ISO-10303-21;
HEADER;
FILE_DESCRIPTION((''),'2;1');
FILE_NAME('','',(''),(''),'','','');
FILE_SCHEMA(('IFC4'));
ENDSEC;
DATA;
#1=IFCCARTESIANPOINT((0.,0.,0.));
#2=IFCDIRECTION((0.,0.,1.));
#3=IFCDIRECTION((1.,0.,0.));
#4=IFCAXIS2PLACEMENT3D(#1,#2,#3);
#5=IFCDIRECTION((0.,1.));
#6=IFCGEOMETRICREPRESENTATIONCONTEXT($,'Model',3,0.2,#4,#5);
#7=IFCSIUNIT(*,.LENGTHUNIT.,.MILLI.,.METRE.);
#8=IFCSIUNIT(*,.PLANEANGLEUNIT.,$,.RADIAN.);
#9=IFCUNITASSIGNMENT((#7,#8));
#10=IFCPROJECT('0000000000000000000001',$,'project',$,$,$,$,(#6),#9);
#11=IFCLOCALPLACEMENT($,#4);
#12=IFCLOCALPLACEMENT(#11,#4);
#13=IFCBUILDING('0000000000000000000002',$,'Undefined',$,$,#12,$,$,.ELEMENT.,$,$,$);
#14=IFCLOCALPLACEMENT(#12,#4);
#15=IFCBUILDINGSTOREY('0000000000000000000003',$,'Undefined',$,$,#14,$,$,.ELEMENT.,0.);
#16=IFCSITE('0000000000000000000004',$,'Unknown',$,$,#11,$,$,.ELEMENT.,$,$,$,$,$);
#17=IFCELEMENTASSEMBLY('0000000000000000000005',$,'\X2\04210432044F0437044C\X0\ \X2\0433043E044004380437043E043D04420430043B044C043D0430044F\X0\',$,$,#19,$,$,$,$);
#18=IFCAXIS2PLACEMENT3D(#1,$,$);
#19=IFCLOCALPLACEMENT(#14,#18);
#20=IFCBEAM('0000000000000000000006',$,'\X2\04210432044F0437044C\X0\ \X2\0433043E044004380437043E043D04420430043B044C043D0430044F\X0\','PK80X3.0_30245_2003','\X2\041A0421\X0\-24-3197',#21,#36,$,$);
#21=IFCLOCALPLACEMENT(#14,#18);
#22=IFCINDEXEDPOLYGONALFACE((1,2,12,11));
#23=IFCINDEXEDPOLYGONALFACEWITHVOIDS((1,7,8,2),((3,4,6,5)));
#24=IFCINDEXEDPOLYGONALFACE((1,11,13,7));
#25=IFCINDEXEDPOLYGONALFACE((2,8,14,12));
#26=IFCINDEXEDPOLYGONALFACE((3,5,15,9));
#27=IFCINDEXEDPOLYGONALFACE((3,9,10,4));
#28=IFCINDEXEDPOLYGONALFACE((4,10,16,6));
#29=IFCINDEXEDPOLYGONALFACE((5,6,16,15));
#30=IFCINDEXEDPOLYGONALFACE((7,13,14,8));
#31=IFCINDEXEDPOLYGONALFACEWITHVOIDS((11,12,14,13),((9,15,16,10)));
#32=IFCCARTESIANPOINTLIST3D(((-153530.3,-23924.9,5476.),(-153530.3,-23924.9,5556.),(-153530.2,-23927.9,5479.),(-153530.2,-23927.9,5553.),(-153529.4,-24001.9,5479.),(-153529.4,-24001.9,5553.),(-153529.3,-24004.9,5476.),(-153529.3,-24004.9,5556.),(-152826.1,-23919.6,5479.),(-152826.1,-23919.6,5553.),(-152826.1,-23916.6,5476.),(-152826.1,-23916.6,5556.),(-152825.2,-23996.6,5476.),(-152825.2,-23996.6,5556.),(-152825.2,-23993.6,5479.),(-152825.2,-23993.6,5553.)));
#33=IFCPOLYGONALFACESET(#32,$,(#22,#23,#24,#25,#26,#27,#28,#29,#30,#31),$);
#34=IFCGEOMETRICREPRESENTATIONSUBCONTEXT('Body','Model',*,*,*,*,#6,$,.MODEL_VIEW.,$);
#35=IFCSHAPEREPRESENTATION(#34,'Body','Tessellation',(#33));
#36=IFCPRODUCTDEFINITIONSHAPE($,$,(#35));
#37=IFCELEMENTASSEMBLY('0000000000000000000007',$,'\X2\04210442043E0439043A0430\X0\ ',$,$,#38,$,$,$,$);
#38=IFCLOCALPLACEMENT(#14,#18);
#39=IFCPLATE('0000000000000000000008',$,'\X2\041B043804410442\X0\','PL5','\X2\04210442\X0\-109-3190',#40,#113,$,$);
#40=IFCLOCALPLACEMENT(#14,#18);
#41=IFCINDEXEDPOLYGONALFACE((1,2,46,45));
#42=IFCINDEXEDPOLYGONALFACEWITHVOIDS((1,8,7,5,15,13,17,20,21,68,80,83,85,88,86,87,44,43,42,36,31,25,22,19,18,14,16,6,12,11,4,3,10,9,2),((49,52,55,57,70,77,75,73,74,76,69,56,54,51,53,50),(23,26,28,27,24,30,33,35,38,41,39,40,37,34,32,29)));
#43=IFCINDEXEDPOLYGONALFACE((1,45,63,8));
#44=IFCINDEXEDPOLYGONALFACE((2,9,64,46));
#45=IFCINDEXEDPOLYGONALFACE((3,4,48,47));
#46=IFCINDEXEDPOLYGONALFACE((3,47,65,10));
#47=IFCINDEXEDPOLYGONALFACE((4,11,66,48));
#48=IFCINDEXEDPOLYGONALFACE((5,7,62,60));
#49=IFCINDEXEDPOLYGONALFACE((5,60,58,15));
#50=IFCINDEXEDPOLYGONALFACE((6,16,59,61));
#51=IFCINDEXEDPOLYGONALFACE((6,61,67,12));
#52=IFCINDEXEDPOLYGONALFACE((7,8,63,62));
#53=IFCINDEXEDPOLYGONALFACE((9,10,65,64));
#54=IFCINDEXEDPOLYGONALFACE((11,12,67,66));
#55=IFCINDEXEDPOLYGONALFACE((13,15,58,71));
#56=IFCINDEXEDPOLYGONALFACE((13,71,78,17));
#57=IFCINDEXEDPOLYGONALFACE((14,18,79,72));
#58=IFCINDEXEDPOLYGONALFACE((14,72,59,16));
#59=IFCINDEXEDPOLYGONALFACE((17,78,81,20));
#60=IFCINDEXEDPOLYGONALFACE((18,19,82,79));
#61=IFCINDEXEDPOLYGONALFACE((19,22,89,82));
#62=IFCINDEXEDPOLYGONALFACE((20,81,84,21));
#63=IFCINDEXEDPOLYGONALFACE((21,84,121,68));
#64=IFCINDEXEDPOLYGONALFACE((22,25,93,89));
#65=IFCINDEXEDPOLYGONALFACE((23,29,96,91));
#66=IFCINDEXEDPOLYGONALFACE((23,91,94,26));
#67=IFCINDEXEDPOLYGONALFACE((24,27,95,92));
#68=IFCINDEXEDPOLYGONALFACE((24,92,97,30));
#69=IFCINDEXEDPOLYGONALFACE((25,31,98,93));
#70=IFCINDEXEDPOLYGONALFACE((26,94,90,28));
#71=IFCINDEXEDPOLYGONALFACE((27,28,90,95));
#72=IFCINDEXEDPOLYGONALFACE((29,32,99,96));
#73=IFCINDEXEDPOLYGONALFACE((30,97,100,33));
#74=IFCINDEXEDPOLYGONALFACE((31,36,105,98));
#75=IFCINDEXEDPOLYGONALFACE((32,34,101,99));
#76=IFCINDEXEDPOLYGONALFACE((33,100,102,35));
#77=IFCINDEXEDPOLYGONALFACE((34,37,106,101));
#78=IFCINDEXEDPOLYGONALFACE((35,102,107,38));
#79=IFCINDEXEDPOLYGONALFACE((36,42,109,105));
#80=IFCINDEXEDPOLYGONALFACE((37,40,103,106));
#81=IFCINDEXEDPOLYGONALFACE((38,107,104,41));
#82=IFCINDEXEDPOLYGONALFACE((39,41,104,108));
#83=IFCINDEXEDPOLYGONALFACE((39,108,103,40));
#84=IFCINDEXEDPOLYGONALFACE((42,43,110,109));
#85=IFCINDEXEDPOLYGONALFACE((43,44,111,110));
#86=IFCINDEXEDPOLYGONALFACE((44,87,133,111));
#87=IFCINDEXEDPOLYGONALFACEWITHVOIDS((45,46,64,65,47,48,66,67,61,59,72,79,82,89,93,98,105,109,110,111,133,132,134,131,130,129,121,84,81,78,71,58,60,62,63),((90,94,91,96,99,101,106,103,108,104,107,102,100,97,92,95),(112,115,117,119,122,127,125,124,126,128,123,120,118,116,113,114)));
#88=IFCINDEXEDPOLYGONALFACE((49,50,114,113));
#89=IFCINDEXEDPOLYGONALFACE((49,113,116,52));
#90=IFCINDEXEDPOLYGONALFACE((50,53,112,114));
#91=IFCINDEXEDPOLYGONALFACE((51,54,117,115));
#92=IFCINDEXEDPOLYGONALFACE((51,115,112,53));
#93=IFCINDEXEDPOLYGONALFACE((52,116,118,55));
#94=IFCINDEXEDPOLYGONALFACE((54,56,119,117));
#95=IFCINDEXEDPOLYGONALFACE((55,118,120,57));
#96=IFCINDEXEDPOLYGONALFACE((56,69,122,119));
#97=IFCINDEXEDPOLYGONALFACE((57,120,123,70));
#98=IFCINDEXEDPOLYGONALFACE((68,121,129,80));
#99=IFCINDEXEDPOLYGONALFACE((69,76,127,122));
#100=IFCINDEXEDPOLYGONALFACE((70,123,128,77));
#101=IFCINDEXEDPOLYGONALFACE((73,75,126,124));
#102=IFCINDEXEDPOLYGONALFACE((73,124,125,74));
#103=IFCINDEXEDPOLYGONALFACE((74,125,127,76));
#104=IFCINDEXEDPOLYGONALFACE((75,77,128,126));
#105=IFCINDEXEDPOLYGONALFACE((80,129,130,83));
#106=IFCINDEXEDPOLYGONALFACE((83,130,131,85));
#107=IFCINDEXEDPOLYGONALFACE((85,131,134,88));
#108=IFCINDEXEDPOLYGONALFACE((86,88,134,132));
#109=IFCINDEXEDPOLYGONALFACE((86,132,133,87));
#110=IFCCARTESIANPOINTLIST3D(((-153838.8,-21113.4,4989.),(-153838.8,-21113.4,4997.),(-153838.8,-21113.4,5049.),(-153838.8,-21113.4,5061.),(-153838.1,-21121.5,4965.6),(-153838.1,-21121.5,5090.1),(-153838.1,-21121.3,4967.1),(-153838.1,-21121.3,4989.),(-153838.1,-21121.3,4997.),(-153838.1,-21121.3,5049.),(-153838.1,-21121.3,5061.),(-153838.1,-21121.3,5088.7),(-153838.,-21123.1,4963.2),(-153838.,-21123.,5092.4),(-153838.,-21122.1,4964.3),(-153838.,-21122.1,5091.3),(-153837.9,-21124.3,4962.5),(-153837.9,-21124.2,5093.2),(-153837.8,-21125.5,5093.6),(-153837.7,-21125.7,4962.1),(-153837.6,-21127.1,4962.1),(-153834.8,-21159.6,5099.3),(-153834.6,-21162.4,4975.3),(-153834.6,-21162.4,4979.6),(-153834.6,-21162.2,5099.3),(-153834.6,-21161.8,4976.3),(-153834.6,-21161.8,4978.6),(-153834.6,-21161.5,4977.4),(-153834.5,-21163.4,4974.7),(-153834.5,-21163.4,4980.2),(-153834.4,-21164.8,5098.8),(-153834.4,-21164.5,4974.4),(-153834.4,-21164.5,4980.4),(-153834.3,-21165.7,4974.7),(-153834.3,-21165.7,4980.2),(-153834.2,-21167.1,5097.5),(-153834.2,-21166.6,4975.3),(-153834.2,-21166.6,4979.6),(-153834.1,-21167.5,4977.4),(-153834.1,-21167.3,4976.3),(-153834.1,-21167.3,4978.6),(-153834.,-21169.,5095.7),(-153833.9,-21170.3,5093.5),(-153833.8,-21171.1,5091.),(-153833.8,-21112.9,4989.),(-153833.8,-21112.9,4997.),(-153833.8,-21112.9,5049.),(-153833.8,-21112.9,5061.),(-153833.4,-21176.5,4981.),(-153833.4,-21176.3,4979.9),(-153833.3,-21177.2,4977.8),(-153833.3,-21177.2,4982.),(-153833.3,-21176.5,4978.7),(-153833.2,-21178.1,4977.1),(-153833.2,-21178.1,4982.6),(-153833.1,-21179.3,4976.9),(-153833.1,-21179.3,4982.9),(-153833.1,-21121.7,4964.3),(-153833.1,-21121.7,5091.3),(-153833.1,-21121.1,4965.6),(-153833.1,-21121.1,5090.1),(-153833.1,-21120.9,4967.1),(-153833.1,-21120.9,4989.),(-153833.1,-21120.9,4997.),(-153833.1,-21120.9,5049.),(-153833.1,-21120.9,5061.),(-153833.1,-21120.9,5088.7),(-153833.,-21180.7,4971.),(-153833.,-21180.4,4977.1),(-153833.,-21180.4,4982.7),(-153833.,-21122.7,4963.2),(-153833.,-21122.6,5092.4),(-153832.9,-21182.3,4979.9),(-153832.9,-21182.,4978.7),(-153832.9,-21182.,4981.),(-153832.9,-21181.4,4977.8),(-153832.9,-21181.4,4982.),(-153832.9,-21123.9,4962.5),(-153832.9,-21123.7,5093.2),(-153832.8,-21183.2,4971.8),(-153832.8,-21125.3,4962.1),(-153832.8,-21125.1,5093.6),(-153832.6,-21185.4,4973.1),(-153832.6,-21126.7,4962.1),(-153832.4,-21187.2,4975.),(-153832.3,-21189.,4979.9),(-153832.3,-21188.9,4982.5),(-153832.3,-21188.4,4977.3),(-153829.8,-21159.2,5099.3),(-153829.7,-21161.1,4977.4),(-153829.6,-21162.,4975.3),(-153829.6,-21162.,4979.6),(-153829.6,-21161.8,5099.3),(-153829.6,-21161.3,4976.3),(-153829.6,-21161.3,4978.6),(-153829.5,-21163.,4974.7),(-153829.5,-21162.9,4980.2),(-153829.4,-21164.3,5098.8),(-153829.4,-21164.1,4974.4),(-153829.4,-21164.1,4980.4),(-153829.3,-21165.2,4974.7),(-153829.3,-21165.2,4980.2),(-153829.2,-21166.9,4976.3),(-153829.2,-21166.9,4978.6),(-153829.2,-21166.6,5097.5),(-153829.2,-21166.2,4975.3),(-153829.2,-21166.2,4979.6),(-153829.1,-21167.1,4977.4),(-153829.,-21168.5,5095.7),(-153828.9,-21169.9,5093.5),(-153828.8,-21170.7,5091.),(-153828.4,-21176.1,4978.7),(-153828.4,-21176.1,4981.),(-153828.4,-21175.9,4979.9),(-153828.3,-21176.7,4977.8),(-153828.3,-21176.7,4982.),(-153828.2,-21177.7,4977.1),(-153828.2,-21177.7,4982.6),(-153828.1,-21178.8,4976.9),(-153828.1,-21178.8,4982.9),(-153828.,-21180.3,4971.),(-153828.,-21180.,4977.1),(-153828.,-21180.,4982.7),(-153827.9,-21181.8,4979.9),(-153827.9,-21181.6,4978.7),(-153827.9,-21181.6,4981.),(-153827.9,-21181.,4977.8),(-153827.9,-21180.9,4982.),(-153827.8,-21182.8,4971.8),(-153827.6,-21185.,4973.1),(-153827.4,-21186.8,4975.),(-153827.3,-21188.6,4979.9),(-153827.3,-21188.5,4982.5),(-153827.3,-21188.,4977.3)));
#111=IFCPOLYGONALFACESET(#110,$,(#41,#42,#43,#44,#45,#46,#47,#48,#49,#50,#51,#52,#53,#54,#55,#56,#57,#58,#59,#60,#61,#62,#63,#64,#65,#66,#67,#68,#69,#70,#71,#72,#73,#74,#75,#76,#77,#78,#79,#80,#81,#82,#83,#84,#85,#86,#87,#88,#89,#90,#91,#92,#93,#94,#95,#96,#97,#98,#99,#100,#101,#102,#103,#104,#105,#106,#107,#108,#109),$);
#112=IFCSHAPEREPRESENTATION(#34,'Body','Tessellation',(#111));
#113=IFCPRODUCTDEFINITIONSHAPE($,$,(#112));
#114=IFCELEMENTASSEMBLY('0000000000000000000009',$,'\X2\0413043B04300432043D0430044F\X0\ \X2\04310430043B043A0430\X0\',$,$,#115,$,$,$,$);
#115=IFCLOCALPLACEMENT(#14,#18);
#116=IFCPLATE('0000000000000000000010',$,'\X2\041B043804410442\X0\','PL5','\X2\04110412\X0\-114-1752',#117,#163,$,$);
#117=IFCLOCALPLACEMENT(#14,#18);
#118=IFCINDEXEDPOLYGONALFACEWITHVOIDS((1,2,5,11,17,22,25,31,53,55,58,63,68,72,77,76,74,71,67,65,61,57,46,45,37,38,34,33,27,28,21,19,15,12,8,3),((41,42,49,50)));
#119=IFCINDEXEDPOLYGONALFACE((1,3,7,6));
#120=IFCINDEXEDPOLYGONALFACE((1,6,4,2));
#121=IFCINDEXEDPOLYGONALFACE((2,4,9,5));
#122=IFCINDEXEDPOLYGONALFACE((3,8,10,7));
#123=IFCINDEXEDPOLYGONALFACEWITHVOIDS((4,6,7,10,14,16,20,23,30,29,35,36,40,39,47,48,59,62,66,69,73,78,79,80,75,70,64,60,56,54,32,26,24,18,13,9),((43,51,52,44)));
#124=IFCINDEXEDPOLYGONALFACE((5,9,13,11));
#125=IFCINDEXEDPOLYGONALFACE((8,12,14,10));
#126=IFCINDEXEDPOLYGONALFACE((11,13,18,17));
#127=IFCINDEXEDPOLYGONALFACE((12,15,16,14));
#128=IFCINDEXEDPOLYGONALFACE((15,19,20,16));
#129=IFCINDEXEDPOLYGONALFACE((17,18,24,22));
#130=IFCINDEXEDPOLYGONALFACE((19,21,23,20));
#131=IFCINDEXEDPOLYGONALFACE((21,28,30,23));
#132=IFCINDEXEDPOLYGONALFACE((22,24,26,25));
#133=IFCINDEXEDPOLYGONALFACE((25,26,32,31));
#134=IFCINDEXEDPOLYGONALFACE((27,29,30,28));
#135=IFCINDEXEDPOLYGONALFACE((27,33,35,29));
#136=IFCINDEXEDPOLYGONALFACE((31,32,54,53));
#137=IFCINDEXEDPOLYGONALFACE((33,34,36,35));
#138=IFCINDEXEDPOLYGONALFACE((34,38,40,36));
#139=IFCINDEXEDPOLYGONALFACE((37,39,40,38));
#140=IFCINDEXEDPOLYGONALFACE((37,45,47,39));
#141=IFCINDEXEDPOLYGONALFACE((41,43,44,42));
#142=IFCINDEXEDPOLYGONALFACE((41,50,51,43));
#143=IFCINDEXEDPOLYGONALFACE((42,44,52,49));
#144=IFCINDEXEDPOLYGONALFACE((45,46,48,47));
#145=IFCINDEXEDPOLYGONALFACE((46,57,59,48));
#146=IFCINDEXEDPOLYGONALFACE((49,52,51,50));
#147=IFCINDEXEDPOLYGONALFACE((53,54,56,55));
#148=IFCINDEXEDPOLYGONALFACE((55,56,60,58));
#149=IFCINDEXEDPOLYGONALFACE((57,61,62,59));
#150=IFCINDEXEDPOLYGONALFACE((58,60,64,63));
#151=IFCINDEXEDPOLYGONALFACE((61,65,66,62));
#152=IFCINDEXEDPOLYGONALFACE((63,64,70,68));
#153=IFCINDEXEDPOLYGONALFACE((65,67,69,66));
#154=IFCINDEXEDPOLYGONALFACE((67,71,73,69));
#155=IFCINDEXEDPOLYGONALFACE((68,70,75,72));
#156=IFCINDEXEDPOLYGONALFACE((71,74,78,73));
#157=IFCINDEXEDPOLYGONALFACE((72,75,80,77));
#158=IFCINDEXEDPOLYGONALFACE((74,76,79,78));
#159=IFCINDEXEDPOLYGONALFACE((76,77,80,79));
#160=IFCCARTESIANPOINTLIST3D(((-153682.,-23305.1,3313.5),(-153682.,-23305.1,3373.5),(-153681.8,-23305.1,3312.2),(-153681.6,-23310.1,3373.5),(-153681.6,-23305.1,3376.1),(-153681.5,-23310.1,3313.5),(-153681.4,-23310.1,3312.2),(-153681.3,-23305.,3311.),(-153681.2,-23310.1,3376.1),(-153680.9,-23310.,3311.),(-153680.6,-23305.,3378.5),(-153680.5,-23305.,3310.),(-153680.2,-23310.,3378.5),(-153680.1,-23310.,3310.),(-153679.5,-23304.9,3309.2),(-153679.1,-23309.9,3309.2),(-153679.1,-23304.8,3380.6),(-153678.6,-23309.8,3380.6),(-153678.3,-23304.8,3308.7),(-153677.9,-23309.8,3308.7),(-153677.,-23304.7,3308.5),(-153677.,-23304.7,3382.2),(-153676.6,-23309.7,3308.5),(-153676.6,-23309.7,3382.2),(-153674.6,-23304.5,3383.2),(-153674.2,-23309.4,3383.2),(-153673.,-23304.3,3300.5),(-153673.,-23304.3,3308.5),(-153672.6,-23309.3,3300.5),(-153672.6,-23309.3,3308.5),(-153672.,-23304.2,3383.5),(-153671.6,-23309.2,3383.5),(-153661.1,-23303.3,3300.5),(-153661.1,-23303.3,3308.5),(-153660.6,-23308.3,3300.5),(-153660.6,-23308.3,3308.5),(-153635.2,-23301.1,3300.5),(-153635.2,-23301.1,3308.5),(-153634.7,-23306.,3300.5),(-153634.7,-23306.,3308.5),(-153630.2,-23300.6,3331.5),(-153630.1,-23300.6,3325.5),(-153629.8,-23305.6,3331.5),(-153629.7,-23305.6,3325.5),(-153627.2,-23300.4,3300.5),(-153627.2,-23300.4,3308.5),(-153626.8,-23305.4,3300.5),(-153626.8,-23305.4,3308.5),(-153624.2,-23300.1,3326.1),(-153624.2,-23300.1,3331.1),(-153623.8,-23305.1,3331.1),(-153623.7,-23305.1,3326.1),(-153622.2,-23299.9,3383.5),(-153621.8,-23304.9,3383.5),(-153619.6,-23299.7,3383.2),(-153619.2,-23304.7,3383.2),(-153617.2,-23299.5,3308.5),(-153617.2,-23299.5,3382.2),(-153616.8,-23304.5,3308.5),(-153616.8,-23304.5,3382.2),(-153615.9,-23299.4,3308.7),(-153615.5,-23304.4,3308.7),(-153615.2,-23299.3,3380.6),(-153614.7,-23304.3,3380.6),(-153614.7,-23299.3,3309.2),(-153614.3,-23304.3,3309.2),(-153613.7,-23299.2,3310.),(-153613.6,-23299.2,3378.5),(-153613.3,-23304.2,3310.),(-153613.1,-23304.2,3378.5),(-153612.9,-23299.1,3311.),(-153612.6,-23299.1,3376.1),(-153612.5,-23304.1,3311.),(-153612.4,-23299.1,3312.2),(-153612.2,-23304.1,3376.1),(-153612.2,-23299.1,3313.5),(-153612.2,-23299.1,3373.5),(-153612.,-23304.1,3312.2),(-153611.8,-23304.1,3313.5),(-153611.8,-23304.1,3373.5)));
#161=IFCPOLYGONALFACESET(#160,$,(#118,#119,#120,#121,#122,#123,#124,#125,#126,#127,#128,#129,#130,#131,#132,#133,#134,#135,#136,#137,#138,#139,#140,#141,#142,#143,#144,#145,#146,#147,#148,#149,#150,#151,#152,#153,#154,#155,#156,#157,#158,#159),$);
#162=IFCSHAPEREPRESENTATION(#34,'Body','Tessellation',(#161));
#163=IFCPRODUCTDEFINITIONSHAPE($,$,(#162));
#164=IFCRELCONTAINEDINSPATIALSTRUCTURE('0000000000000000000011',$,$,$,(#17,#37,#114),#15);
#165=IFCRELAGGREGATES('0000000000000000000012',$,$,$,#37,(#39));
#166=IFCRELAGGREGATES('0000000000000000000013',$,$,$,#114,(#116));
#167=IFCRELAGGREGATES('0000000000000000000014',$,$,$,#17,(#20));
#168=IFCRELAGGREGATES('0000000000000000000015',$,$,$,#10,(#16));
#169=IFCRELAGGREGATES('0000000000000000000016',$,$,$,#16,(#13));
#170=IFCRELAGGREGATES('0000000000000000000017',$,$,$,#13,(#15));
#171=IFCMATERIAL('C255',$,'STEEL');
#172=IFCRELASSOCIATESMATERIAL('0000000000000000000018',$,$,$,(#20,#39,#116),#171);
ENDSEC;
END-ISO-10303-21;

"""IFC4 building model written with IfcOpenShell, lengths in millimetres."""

from ifc_helpers import new_model, si_unit, direction, frame, origin_with_axes, place, context, subcontext, project, spatial, line, arc, indexed_curve, outline, extrude, material, element, aggregate, save


model = new_model("IFC4")

# Units and contexts
model_context = context("Model", 3, precision=0.2, world=origin_with_axes(), true_north=direction((0.0, 1.0)))
body_context = subcontext(model_context, "Body", "Model", "MODEL_VIEW")
ifc_project = project(units=[si_unit("LENGTHUNIT", "METRE", prefix="MILLI"), si_unit("PLANEANGLEUNIT", "RADIAN")], contexts=[model_context])

# Site, building, storey
site_placement = place(None, origin_with_axes())
site = spatial("IfcSite", under=ifc_project, at=site_placement, Name="Unknown", CompositionType="ELEMENT")
building_placement = place(site_placement, origin_with_axes())
building = spatial("IfcBuilding", under=site, at=building_placement, Name="Undefined", CompositionType="ELEMENT")
storey_placement = place(building_placement, origin_with_axes())
storey = spatial("IfcBuildingStorey", under=building, at=storey_placement, Name="Undefined", CompositionType="ELEMENT", Elevation=0.0)

# Element assembly, beam
assembly_1_placement = place(storey_placement, frame((-153529.8, -23964.9, 5516.0), z_axis=(0.01183, -0.99993, 0.0), x_axis=(0.99993, 0.01183, 0.0)))
assembly_1 = element("IfcElementAssembly", 1, at=assembly_1_placement, inside=storey, Name="Связь горизонтальная")
ifc_material_1 = material(Name="C255", Category="STEEL")
beam_placement = place(assembly_1_placement, origin_with_axes())
beam = element("IfcBeam", 2, at=beam_placement, material=ifc_material_1, Name="Связь горизонтальная", Description="PK80X3.0_30245_2003", ObjectType="КС-24-3197", context=body_context, shape_type="SolidModel", body=[
    extrude(outline(indexed_curve([(-40.0, -40.0), (40.0, -40.0), (40.0, 40.0), (-40.0, 40.0)], segments=[line(1, 2, 3, 4, 1)]), holes=[indexed_curve([(-37.0, -37.0), (-37.0, 37.0), (37.0, 37.0), (37.0, -37.0)], segments=[line(1, 2, 3, 4, 1)])]), frame((0.0, 0.0, 0.0), z_axis=(-1.0, 0.0, 0.0), x_axis=(0.0, 0.0, 1.0)), (0.0, 0.0, -1.0), 704.2),
])

# Element assembly, plate, voiding features
assembly_2_placement = place(storey_placement, frame((-153844.1, -21081.5, 1298.5), z_axis=(-0.086114, 0.996285, 0.0), x_axis=(0.0, 0.0, 1.0)))
assembly_2 = element("IfcElementAssembly", 3, at=assembly_2_placement, inside=storey, Name="Стойка ")
plate_1_placement = place(assembly_2_placement, frame((3674.1, 5.0, -109.7), z_axis=(0.000023, -1.0, 0.000007), x_axis=(0.986646, 0.000024, 0.162881)))
plate_1 = element("IfcPlate", 4, at=plate_1_placement, material=ifc_material_1, Name="Лист", Description="PL5", ObjectType="Ст-109-3190", context=body_context, shape_type="SolidModel", body=[
    extrude(outline(indexed_curve([(0.0, 10.0), (2.9, 2.9), (10.0, 0.0), (120.0, 0.0), (127.1, 2.9), (130.0, 10.0), (130.0, 44.7), (128.8, 48.0), (125.8, 49.6), (98.6, 54.1), (99.9, 62.0), (88.0, 64.0), (86.7, 56.1), (35.4, 64.6), (36.7, 72.5), (28.8, 73.8), (27.5, 65.9), (5.8, 69.5), (1.8, 68.3), (0.0, 64.5)], segments=[arc(1, 2, 3), line(3, 4), arc(4, 5, 6), line(6, 7), arc(7, 8, 9), line(9, 10, 11, 12, 13, 14, 15, 16, 17, 18), arc(18, 19, 20), line(20, 1)])), frame((0.0, 0.0, 2.5), z_axis=(0.0, 0.0, 1.0), x_axis=(1.0, 0.0, 0.0)), (0.0, 0.0, -1.0), 5.0),
])
voiding_feature_1_placement = place(plate_1_placement, frame((9.0, 10.0, 10.0), z_axis=(-0.159897, -0.987134, 0.0), x_axis=(0.0, 0.0, -1.0)))
element("IfcVoidingFeature", 5, at=voiding_feature_1_placement, cuts=plate_1, Name="Балка", ObjectType="(?)", PredefinedType="HOLE", context=body_context, shape_type="SolidModel", body=[
    extrude(outline(indexed_curve([(3.0, 0.0), (2.8, 1.1), (2.1, 2.1), (1.1, 2.8), (0.0, 3.0), (-1.1, 2.8), (-2.1, 2.1), (-2.8, 1.1), (-3.0, 0.0), (-2.8, -1.1), (-2.1, -2.1), (-1.1, -2.8), (0.0, -3.0), (1.1, -2.8), (2.1, -2.1), (2.8, -1.1)], segments=[line(1, 2, 3, 4, 5, 6, 7, 8, 9, 10, 11, 12, 13, 14, 15, 16, 1)])), frame((0.0, 0.0, 0.0), z_axis=(-1.0, 0.0, 0.0), x_axis=(0.0, 0.0, 1.0)), (0.0, 0.0, -1.0), 20.0),
])
voiding_feature_2_placement = place(plate_1_placement, frame((9.0, 25.0, 10.0), z_axis=(-0.159897, -0.987134, 0.0), x_axis=(0.0, 0.0, -1.0)))
element("IfcVoidingFeature", 6, at=voiding_feature_2_placement, cuts=plate_1, Name="Балка", ObjectType="(?)", PredefinedType="HOLE", context=body_context, shape_type="SolidModel", body=[
    extrude(outline(indexed_curve([(3.0, 0.0), (2.8, 1.1), (2.1, 2.1), (1.1, 2.8), (0.0, 3.0), (-1.1, 2.8), (-2.1, 2.1), (-2.8, 1.1), (-3.0, 0.0), (-2.8, -1.1), (-2.1, -2.1), (-1.1, -2.8), (0.0, -3.0), (1.1, -2.8), (2.1, -2.1), (2.8, -1.1)], segments=[line(1, 2, 3, 4, 5, 6, 7, 8, 9, 10, 11, 12, 13, 14, 15, 16, 1)])), frame((0.0, 0.0, 0.0), z_axis=(-1.0, 0.0, 0.0), x_axis=(0.0, 0.0, 1.0)), (0.0, 0.0, -1.0), 20.0),
])

# Element assembly, plate, voiding feature
assembly_3_placement = place(storey_placement, frame((-153597.5, -23933.9, 3248.5), z_axis=(-0.996285, -0.086114, -0.000024), x_axis=(-0.086114, 0.996285, 0.0)))
assembly_3 = element("IfcElementAssembly", 7, at=assembly_3_placement, inside=storey, Name="Главная балка")
plate_2_placement = place(assembly_3_placement, frame((631.2, -135.0, -40.0), z_axis=(-1.0, -0.000054, 0.0), x_axis=(0.0, 0.000054, 1.0)))
plate_2 = element("IfcPlate", 8, at=plate_2_placement, material=ifc_material_1, Name="Лист", Description="PL5", ObjectType="БВ-114-1752", context=body_context, shape_type="SolidModel", body=[
    extrude(outline(indexed_curve([(0.0, 10.0), (2.9, 2.9), (10.0, 0.0), (60.0, 0.0), (67.1, 2.9), (70.0, 10.0), (70.0, 70.0), (68.5, 73.5), (65.0, 75.0), (61.0, 75.0), (61.0, 83.0), (49.0, 83.0), (49.0, 75.0), (23.0, 75.0), (23.0, 83.0), (15.0, 83.0), (15.0, 75.0), (5.0, 75.0), (1.5, 73.5), (0.0, 70.0)], segments=[arc(1, 2, 3), line(3, 4), arc(4, 5, 6), line(6, 7), arc(7, 8, 9), line(9, 10, 11, 12, 13, 14, 15, 16, 17, 18), arc(18, 19, 20), line(20, 1)])), frame((0.0, 0.0, 2.5), z_axis=(0.0, 0.0, 1.0), x_axis=(1.0, 0.0, 0.0)), (0.0, 0.0, -1.0), 5.0),
])
voiding_feature_3_placement = place(plate_2_placement, frame((15.0, 55.0, 10.0), z_axis=(0.007997, -0.999968, -0.000026), x_axis=(0.0, 0.000026, -1.0)))
element("IfcVoidingFeature", 9, at=voiding_feature_3_placement, cuts=plate_2, Name="Балка", ObjectType="(?)", PredefinedType="HOLE", context=body_context, shape_type="SolidModel", body=[
    extrude(outline(indexed_curve([(2.5, -3.0), (3.0, 3.0), (-3.0, 3.0), (-2.5, -3.0)], segments=[line(1, 2, 3, 4, 1)])), frame((0.0, 0.0, 0.0), z_axis=(-1.0, 0.0, 0.0), x_axis=(0.0, 0.0, 1.0)), (0.0, 0.0, -1.0), 20.0),
])

aggregate(assembly_2, [plate_1])

aggregate(assembly_3, [plate_2])

aggregate(assembly_1, [beam])

save(model, "model.ifc")
